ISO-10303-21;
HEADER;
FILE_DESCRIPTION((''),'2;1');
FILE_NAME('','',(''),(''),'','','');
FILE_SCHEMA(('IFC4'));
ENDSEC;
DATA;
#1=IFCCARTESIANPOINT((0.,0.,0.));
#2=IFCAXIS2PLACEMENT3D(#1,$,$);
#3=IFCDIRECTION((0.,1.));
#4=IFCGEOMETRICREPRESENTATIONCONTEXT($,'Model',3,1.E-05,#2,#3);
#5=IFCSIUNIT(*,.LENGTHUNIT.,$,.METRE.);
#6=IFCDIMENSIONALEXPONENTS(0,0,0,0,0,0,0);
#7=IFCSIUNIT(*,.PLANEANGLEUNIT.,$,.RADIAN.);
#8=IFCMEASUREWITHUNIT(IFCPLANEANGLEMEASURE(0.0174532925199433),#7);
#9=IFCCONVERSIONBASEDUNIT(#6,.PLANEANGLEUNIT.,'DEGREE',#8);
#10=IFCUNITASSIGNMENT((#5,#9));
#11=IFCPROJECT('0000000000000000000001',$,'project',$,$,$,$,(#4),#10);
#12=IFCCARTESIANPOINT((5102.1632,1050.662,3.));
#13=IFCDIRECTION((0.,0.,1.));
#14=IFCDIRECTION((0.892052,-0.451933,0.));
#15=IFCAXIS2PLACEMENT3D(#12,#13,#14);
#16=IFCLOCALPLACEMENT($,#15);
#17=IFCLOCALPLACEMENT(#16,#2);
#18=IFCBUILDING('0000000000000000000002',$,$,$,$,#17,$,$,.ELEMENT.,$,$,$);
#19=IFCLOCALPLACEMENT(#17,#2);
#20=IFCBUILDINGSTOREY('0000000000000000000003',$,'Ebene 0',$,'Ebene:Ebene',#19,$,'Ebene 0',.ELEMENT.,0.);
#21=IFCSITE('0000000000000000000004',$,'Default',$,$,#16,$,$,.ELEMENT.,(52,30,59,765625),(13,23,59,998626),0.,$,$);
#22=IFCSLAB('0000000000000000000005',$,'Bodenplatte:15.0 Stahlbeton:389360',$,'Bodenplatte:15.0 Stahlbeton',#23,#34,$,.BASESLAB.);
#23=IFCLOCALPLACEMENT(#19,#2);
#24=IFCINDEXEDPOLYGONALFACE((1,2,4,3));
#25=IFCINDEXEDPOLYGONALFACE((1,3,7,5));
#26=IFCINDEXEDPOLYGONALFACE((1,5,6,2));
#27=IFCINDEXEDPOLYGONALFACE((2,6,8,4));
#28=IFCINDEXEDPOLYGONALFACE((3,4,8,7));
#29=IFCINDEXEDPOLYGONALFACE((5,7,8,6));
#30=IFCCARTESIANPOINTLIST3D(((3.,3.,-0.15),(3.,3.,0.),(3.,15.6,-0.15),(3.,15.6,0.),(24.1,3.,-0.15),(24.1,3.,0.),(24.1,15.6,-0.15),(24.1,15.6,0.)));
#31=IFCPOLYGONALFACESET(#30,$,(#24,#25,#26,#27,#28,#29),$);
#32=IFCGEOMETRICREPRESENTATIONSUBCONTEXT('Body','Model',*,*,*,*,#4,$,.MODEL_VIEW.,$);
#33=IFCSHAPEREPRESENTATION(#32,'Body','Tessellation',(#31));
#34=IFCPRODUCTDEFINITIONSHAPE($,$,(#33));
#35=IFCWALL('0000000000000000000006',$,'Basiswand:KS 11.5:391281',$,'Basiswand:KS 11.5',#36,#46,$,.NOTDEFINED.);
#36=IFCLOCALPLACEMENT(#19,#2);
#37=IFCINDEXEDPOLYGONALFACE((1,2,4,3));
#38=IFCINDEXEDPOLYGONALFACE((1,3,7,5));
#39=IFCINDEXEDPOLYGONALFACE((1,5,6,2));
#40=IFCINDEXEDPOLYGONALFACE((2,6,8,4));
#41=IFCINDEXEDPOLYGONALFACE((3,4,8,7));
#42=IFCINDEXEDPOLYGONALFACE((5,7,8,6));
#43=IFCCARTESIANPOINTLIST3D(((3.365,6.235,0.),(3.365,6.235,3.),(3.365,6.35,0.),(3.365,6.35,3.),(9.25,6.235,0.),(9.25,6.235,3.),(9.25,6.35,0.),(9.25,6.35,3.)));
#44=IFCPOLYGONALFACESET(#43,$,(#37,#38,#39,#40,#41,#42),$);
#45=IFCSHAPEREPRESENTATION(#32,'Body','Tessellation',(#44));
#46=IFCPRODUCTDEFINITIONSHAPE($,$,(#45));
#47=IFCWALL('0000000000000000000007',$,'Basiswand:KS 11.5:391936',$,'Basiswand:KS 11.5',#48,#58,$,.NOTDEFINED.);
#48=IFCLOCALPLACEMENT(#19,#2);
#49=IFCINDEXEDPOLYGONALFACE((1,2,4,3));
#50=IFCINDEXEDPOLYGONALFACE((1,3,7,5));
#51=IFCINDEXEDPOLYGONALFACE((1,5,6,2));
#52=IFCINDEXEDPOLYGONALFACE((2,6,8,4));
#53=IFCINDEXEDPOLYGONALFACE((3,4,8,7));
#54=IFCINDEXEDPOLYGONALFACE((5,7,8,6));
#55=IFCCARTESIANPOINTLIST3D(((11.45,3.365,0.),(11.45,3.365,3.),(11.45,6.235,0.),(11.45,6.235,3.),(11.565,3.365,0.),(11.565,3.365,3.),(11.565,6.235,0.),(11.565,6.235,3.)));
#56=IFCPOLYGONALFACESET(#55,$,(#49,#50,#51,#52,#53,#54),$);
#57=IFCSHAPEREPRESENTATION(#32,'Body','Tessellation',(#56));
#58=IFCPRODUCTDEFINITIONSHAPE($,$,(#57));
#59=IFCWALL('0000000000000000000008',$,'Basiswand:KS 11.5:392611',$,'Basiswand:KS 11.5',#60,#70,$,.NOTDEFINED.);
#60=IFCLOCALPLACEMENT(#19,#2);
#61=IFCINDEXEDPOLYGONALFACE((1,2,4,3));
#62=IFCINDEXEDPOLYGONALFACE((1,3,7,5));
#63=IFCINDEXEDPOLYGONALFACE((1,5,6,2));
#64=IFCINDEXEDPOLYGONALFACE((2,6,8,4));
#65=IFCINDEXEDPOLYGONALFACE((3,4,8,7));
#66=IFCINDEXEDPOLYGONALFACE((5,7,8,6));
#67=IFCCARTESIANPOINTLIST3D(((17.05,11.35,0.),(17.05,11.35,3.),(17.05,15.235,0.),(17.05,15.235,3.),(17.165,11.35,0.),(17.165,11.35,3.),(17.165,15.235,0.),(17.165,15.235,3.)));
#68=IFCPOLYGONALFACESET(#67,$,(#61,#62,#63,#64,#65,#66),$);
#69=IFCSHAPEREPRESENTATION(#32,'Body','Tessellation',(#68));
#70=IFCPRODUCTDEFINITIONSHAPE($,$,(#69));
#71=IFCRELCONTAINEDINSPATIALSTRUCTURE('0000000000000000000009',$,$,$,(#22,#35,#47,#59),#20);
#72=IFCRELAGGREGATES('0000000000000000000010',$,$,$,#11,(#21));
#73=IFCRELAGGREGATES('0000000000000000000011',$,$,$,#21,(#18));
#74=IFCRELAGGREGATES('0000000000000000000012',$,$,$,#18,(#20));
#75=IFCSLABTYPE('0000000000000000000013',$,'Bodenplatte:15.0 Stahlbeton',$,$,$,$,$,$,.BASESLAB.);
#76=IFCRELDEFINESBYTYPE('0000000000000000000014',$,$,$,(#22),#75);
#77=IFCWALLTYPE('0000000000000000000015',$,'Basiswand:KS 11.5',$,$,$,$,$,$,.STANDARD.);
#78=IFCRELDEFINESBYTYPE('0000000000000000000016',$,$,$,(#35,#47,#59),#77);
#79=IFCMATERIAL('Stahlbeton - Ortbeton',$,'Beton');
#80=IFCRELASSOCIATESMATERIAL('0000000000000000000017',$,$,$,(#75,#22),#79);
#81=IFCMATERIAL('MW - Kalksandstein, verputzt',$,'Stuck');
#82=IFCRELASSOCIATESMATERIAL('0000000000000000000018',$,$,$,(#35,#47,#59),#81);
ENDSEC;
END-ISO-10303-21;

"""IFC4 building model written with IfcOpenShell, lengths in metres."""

from ifc_helpers import new_model, entity, si_unit, converted_unit, direction, frame, origin, place, context, subcontext, project, spatial, indexed_curve, outline, extrude, material, type_object, element, save


model = new_model("IFC4")

# Units and contexts
model_context = context("Model", 3, precision=1e-05, world=origin(), true_north=direction((0.0, 1.0)))
body_context = subcontext(model_context, "Body", "Model", "MODEL_VIEW")
ifc_project = project(units=[si_unit("LENGTHUNIT", "METRE"), converted_unit("PLANEANGLEUNIT", "DEGREE", entity("IfcPlaneAngleMeasure", 0.0174532925199433), si_unit("PLANEANGLEUNIT", "RADIAN"), dimensions=[0, 0, 0, 0, 0, 0, 0])], contexts=[model_context])

# Site, building, storey
site_placement = place(None, frame((5102.1632, 1050.662, 3.0), z_axis=(0.0, 0.0, 1.0), x_axis=(0.892052, -0.451933, 0.0)))
site = spatial("IfcSite", under=ifc_project, at=site_placement, Name="Default", CompositionType="ELEMENT", RefLatitude=(52, 30, 59, 765625), RefLongitude=(13, 23, 59, 998626), RefElevation=0.0)
building_placement = place(site_placement, origin())
building = spatial("IfcBuilding", under=site, at=building_placement, CompositionType="ELEMENT")
storey_placement = place(building_placement, origin())
storey = spatial("IfcBuildingStorey", under=building, at=storey_placement, Name="Ebene 0", ObjectType="Ebene:Ebene", LongName="Ebene 0", CompositionType="ELEMENT", Elevation=0.0)

# Slab
ifc_material_1 = material(Name="Stahlbeton - Ortbeton", Category="Beton")
slab_type = type_object("IfcSlabType", Name="Bodenplatte:15.0 Stahlbeton", PredefinedType="BASESLAB", material=ifc_material_1)
slab_placement = place(storey_placement, origin())
element("IfcSlab", 1, at=slab_placement, inside=storey, type_object=slab_type, material=ifc_material_1, Name="Bodenplatte:15.0 Stahlbeton:389360", ObjectType="Bodenplatte:15.0 Stahlbeton", PredefinedType="BASESLAB", context=body_context, shape_type="SweptSolid", body=[
    extrude(outline(indexed_curve([(-6.3, -10.55), (6.3, -10.55), (6.3, 10.55), (-6.3, 10.55), (-6.3, -10.55)], self_intersect=False)), frame((13.55, 9.3, 0.0), z_axis=(0.0, 0.0, -1.0), x_axis=(0.0, 1.0, 0.0)), (0.0, 0.0, 1.0), 0.15),
])

# Walls
ifc_material_2 = material(Name="MW - Kalksandstein, verputzt", Category="Stuck")
wall_type = type_object("IfcWallType", Name="Basiswand:KS 11.5", PredefinedType="STANDARD")
wall_1_placement = place(storey_placement, frame((9.25, 6.2925, 0.0), z_axis=(0.0, 0.0, 1.0), x_axis=(-1.0, 0.0, 0.0)))
element("IfcWall", 2, at=wall_1_placement, inside=storey, type_object=wall_type, material=ifc_material_2, Name="Basiswand:KS 11.5:391281", ObjectType="Basiswand:KS 11.5", PredefinedType="NOTDEFINED", context=body_context, shape_type="SweptSolid", body=[
    extrude(outline(indexed_curve([(5.885, 0.0575), (0.0, 0.0575), (0.0, -0.0575), (5.885, -0.0575), (5.885, 0.0575)], self_intersect=False)), origin(), (0.0, 0.0, 1.0), 3.0),
])
wall_2_placement = place(storey_placement, frame((11.5075, 6.235, 0.0), z_axis=(0.0, 0.0, 1.0), x_axis=(0.0, -1.0, 0.0)))
element("IfcWall", 3, at=wall_2_placement, inside=storey, type_object=wall_type, material=ifc_material_2, Name="Basiswand:KS 11.5:391936", ObjectType="Basiswand:KS 11.5", PredefinedType="NOTDEFINED", context=body_context, shape_type="SweptSolid", body=[
    extrude(outline(indexed_curve([(2.87, 0.0575), (0.0, 0.0575), (0.0, -0.0575), (2.87, -0.0575), (2.87, 0.0575)], self_intersect=False)), origin(), (0.0, 0.0, 1.0), 3.0),
])
wall_3_placement = place(storey_placement, frame((17.1075, 15.235, 0.0), z_axis=(0.0, 0.0, 1.0), x_axis=(0.0, -1.0, 0.0)))
element("IfcWall", 4, at=wall_3_placement, inside=storey, type_object=wall_type, material=ifc_material_2, Name="Basiswand:KS 11.5:392611", ObjectType="Basiswand:KS 11.5", PredefinedType="NOTDEFINED", context=body_context, shape_type="SweptSolid", body=[
    extrude(outline(indexed_curve([(3.885, 0.0575), (0.0, 0.0575), (0.0, -0.0575), (3.885, -0.0575), (3.885, 0.0575)], self_intersect=False)), origin(), (0.0, 0.0, 1.0), 3.0),
])

save(model, "model.ifc")
